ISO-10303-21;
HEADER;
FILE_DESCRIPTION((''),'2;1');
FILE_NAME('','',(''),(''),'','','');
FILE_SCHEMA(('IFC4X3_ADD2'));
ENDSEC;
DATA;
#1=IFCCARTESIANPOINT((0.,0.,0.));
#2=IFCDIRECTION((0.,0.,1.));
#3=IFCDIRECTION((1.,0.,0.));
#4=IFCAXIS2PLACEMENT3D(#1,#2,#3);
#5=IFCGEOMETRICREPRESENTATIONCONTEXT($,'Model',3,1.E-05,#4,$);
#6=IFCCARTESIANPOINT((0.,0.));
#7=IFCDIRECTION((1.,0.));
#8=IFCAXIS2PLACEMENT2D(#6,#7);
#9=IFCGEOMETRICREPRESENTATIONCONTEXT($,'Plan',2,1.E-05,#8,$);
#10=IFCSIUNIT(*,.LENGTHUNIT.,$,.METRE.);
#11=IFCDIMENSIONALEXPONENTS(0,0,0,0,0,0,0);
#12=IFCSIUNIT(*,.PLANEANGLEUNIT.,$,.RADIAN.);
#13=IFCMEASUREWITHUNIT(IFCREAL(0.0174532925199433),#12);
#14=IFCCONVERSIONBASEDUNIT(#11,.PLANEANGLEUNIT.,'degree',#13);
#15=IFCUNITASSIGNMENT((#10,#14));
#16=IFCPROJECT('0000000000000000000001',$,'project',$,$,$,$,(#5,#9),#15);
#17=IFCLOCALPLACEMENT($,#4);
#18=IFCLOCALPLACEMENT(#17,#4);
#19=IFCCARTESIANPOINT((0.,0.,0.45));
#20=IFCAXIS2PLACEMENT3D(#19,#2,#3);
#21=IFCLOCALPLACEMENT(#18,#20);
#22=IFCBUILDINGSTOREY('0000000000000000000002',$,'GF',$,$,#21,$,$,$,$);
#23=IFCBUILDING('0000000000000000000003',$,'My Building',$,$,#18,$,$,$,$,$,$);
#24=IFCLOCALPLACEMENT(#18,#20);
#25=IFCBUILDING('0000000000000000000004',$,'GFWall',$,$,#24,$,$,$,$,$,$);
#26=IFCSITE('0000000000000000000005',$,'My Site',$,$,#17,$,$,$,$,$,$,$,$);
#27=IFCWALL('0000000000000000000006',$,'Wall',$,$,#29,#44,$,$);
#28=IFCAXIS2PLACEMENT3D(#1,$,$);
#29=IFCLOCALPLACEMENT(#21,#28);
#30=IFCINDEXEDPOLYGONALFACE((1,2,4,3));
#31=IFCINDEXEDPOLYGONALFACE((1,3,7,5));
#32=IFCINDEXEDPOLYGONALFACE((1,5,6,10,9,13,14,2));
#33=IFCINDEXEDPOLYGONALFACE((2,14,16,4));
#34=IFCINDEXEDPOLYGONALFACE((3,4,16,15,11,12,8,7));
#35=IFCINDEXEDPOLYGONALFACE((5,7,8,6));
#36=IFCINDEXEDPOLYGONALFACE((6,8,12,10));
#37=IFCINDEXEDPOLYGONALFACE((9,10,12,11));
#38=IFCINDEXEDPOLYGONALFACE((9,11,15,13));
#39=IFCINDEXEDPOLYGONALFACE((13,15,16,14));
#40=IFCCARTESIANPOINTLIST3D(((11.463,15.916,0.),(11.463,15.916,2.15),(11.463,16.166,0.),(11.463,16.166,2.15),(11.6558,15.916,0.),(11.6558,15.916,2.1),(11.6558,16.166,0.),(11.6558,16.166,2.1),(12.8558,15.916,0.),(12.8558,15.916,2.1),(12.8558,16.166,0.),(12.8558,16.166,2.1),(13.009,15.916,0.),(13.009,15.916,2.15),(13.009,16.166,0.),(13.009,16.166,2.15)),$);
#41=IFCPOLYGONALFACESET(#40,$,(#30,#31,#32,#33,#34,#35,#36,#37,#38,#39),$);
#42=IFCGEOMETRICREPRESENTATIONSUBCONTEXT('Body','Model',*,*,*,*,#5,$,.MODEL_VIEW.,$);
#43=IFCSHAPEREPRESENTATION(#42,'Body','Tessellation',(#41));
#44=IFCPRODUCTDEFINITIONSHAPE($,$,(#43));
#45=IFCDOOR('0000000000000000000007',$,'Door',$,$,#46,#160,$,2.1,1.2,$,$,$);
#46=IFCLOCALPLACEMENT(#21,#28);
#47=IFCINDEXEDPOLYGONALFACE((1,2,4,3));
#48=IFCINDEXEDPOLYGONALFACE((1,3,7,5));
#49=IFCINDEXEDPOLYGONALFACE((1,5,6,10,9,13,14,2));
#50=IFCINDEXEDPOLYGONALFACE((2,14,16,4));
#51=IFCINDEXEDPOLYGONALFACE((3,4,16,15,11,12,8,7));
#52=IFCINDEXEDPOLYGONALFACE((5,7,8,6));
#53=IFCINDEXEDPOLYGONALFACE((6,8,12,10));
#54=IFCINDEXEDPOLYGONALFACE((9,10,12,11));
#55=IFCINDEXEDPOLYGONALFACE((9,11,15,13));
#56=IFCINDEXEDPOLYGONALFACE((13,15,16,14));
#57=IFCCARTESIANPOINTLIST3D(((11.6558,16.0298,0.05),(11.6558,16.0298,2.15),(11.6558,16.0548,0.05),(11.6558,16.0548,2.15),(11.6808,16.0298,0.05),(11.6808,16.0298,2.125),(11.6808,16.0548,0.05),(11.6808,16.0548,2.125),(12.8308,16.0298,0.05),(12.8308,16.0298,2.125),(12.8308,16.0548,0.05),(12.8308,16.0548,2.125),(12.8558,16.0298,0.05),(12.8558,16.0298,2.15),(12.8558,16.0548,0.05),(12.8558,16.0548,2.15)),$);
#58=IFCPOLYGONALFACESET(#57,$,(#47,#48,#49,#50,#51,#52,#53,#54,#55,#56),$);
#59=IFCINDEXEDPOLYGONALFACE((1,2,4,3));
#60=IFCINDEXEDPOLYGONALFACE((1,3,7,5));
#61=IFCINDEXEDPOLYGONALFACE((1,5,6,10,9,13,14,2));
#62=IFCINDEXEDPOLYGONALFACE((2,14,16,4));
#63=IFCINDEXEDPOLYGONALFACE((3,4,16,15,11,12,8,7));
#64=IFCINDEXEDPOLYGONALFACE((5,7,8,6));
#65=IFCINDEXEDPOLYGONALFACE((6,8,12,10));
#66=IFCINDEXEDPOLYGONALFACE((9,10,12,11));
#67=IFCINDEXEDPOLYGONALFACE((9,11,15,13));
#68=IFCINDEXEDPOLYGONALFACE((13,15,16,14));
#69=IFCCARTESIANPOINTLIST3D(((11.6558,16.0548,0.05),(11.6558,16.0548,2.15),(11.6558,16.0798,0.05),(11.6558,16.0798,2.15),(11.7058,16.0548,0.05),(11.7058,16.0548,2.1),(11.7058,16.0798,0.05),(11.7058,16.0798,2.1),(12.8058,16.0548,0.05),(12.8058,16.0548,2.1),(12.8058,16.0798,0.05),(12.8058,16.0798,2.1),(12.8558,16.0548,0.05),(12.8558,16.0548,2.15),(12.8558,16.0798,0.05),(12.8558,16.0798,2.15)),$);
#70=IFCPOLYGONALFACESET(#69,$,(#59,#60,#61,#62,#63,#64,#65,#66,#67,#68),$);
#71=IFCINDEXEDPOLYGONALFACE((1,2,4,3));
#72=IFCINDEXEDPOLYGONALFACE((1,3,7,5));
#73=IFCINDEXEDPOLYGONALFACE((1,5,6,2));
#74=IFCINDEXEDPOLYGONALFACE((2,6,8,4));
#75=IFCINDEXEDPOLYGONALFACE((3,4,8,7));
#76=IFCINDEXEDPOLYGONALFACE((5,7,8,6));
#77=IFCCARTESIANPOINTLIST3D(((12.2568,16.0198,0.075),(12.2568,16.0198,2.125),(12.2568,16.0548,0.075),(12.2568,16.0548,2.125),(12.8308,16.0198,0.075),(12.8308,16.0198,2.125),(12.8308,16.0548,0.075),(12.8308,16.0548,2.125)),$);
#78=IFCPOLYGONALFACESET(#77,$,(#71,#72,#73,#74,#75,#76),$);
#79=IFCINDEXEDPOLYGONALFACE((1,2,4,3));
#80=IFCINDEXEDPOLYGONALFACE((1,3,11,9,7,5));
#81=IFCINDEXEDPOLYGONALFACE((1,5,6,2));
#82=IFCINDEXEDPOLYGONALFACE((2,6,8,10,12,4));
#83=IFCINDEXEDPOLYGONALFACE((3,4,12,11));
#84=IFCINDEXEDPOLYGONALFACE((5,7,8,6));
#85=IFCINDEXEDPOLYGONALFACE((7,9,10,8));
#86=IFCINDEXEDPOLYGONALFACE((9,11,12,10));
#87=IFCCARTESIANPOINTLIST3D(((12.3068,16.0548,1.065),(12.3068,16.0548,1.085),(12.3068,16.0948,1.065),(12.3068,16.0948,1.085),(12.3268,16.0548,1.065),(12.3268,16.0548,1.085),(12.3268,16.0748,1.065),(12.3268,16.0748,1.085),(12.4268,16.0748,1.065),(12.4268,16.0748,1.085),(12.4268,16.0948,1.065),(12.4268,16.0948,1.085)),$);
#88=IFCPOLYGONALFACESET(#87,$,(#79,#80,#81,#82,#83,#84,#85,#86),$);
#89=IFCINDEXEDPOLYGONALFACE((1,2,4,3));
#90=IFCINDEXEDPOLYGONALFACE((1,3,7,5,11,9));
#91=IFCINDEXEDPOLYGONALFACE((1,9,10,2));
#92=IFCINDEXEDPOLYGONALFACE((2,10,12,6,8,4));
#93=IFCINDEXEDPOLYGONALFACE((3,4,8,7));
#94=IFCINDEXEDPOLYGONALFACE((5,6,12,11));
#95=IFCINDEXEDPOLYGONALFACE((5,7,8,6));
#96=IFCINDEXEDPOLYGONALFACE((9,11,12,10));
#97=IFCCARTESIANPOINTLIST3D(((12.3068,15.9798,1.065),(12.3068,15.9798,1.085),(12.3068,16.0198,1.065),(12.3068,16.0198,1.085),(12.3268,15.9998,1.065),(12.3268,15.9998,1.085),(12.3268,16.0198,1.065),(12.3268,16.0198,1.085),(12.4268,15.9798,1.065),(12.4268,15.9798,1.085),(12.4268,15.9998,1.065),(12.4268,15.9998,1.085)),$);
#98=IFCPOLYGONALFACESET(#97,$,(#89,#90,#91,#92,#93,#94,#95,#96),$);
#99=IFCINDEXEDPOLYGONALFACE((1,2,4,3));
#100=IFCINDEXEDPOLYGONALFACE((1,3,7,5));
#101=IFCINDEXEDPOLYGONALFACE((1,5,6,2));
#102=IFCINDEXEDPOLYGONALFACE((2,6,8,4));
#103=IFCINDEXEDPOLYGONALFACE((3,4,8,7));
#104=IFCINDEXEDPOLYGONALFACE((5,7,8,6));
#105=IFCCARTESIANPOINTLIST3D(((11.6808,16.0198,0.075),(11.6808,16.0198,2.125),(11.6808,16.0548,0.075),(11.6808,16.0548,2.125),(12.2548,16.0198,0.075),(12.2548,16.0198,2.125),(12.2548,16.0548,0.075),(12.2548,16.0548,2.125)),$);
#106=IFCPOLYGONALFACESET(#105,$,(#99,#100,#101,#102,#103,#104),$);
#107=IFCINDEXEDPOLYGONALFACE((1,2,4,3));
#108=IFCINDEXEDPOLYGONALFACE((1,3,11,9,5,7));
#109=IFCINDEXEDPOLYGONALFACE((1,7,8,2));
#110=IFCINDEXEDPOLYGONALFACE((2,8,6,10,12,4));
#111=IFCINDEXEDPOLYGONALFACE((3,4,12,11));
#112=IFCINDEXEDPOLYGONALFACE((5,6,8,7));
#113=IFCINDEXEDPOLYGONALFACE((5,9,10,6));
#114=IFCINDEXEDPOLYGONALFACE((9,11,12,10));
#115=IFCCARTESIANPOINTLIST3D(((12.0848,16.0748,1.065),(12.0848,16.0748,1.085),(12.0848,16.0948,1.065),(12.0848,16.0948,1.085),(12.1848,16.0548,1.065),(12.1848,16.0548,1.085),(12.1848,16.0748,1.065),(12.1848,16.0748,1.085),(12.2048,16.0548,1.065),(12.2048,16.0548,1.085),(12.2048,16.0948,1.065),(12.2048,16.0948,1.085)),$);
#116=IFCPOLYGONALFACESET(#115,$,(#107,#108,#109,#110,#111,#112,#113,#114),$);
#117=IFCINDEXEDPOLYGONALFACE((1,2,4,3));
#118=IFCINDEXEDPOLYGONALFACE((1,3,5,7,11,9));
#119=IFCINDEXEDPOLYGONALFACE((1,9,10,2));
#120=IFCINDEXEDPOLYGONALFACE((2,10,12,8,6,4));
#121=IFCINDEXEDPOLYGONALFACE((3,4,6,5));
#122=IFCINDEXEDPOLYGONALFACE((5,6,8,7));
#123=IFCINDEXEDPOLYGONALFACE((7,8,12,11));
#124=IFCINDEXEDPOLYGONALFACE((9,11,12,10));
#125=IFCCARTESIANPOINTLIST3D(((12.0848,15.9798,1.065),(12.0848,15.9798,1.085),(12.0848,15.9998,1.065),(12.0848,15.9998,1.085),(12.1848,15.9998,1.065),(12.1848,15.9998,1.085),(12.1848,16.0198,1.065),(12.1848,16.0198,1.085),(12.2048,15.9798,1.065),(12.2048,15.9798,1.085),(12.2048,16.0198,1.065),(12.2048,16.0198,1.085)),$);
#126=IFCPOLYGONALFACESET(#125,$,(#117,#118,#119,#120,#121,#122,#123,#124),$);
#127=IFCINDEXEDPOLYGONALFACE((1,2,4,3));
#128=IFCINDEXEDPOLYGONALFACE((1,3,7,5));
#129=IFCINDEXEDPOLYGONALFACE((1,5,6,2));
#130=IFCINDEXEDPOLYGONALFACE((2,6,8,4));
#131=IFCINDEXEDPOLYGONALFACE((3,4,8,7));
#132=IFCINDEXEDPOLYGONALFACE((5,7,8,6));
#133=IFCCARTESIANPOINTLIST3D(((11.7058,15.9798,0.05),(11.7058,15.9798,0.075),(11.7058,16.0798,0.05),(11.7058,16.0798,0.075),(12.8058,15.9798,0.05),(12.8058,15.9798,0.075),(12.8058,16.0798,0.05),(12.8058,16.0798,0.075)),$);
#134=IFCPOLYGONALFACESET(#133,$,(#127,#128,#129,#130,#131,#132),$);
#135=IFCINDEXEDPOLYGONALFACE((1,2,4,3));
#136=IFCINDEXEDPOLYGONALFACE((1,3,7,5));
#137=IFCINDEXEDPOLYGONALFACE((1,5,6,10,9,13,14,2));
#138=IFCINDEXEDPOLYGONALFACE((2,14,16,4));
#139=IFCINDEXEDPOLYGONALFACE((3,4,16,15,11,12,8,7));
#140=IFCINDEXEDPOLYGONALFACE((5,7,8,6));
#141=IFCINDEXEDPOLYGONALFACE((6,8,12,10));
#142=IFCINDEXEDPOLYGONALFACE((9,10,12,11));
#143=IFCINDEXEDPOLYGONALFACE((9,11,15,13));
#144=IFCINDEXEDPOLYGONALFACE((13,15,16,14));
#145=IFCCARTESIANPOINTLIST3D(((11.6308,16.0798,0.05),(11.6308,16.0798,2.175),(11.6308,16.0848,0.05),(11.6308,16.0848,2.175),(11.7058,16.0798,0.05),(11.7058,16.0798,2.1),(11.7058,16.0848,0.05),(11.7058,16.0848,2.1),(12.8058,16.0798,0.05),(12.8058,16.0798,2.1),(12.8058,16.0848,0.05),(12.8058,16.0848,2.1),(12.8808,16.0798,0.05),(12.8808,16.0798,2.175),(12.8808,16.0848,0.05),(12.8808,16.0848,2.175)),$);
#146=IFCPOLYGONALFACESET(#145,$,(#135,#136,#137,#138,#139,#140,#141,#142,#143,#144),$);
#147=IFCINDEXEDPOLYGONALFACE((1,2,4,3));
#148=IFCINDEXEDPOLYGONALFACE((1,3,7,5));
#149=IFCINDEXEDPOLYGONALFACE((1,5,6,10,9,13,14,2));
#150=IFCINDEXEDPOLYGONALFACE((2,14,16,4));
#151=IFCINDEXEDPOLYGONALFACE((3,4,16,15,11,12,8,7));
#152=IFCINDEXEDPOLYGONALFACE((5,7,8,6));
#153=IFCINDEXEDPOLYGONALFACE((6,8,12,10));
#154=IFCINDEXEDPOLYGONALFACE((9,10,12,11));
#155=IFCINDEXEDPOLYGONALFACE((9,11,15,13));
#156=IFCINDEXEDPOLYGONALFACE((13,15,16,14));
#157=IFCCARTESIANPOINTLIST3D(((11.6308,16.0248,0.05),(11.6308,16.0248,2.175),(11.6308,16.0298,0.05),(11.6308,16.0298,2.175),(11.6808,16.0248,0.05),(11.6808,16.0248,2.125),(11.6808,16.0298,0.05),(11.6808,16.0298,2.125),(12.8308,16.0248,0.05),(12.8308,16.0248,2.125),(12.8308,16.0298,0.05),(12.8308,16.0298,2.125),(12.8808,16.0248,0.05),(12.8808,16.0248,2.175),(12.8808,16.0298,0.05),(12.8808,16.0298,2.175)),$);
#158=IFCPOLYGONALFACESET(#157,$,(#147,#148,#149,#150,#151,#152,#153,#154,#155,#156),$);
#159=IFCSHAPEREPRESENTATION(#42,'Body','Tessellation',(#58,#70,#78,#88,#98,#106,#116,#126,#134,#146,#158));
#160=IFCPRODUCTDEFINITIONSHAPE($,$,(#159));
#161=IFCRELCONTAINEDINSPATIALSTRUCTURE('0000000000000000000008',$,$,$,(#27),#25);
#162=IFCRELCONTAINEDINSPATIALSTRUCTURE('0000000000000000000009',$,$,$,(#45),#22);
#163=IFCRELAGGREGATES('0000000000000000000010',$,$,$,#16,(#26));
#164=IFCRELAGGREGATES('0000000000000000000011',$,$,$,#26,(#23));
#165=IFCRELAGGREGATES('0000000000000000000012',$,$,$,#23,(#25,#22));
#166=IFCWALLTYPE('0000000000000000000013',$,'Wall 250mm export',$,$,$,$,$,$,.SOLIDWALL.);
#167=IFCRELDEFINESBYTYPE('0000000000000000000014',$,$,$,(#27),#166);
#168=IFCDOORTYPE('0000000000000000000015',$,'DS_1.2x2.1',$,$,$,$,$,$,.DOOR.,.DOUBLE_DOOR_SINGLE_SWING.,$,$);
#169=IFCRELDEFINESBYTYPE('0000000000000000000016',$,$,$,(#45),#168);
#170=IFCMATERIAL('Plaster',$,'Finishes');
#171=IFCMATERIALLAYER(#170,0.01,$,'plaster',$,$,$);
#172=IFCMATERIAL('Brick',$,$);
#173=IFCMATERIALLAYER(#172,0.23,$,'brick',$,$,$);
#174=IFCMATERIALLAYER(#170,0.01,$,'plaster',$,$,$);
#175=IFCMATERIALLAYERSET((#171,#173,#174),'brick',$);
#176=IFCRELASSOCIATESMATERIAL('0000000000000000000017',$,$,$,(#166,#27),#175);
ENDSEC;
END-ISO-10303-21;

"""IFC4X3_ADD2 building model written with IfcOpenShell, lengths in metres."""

from ifc_helpers import new_model, entity, si_unit, converted_unit, frame, origin_with_axes, origin_2d_with_axis, place, context, subcontext, project, spatial, line, indexed_curve, outline, extrude, shape, source, transform, mapped, material, layer, layer_set, layer_usage, type_object, type_shapes, element, fill, save


model = new_model("IFC4X3_ADD2")

# Units and contexts
model_context = context("Model", 3, precision=1e-05, world=origin_with_axes())
plan_context = context("Plan", 2, precision=1e-05, world=origin_2d_with_axis())
body_context_1 = subcontext(model_context, "Body", "Model", "MODEL_VIEW")
body_context_2 = subcontext(plan_context, "Body", "Plan", "PLAN_VIEW")
ifc_project = project(units=[si_unit("LENGTHUNIT", "METRE"), converted_unit("PLANEANGLEUNIT", "degree", entity("IfcReal", 0.0174532925199433), si_unit("PLANEANGLEUNIT", "RADIAN"), dimensions=[0, 0, 0, 0, 0, 0, 0])], contexts=[model_context, plan_context])

# Site, buildings
site_placement = place(None, origin_with_axes())
site = spatial("IfcSite", under=ifc_project, at=site_placement, Name="My Site")
building_1_placement = place(site_placement, origin_with_axes())
building_1 = spatial("IfcBuilding", under=site, at=building_1_placement, Name="My Building")
building_2_placement = place(building_1_placement, frame((0.0, 0.0, 0.45), z_axis=(0.0, 0.0, 1.0), x_axis=(1.0, 0.0, 0.0)))
building_2 = spatial("IfcBuilding", under=building_1, at=building_2_placement, Name="GFWall")

# Shared definitions
ifc_material_1 = material(Name="Plaster", Category="Finishes")

# Shared definitions
storey_placement = place(building_1_placement, frame((0.0, 0.0, 0.45), z_axis=(0.0, 0.0, 1.0), x_axis=(1.0, 0.0, 0.0)))
storey = spatial("IfcBuildingStorey", under=building_1, at=storey_placement, Name="GF")

# Shared definitions
ifc_layer_1 = layer(ifc_material_1, 0.01, Name="plaster")
ifc_material_2 = material(Name="Brick")
ifc_layer_2 = layer(ifc_material_2, 0.23, Name="brick")
ifc_layer_3 = layer(ifc_material_1, 0.01, Name="plaster")
ifc_layer_set_1 = layer_set([ifc_layer_1, ifc_layer_2, ifc_layer_3], Name="brick")
wall_type_1 = type_object("IfcWallType", Name="Wall 250mm export", PredefinedType="SOLIDWALL", material=ifc_layer_set_1)

# Wall, opening, door
shared_shape_1 = source(origin_with_axes(), body_context_1, "Body", "SweptSolid", [
    extrude(outline(indexed_curve([(0.0, 0.0), (1.2, 0.0), (1.2, 2.1), (0.0, 2.1)], segments=[line(1, 2, 3, 4, 1)])), frame((0.0, -0.6, 0.0), z_axis=(0.0, -1.0, 0.0), x_axis=(1.0, 0.0, 0.0)), (0.0, 0.0, -1.0), 1.2),
])
door_type_1 = type_object("IfcDoorType", Name="DS_1.2x2.1", OperationType="DOUBLE_DOOR_SINGLE_SWING", PredefinedType="DOOR")
shared_shape_2 = source(origin_with_axes(), body_context_1, "Body", "SweptSolid", [
    extrude(outline(indexed_curve([(0.0, 0.0), (0.0, 2.1), (1.2, 2.1), (1.2, 0.0), (1.175, 0.0), (1.175, 2.075), (0.025, 2.075), (0.025, 0.0)], segments=[line(1, 2, 3, 4, 5, 6, 7, 8, 1)])), frame((0.0, 0.025, 0.0), z_axis=(0.0, -1.0, 0.0), x_axis=(1.0, 0.0, 0.0)), (0.0, 0.0, -1.0), 0.025),
    extrude(outline(indexed_curve([(0.0, 0.0), (0.0, 2.1), (1.2, 2.1), (1.2, 0.0), (1.15, 0.0), (1.15, 2.05), (0.05, 2.05), (0.05, 0.0)], segments=[line(1, 2, 3, 4, 5, 6, 7, 8, 1)])), frame((0.0, 0.0, 0.0), z_axis=(0.0, -1.0, 0.0), x_axis=(1.0, 0.0, 0.0)), (0.0, 0.0, -1.0), 0.025),
    extrude(outline(indexed_curve([(0.0, 0.0), (0.574, 0.0), (0.574, 0.035), (0.0, 0.035)], segments=[line(1, 2, 3, 4, 1)])), frame((0.025, 0.025, 0.025), z_axis=(0.0, 0.0, 1.0), x_axis=(1.0, 0.0, 0.0)), (0.0, 0.0, 1.0), 2.05),
    extrude(outline(indexed_curve([(0.0, 0.0), (0.0, -0.04), (-0.12, -0.04), (-0.12, -0.02), (-0.02, -0.02), (-0.02, 0.0)], segments=[line(1, 2, 3, 4, 5, 6, 1)])), frame((0.549, 0.025, 1.015), z_axis=(0.0, 0.0, 1.0), x_axis=(1.0, 0.0, 0.0)), (0.0, 0.0, 1.0), 0.02),
    extrude(outline(indexed_curve([(0.0, 0.0), (0.0, 0.04), (-0.12, 0.04), (-0.12, 0.02), (-0.02, 0.02), (-0.02, 0.0)], segments=[line(1, 2, 3, 4, 5, 6, 1)])), frame((0.549, 0.06, 1.015), z_axis=(0.0, 0.0, 1.0), x_axis=(1.0, 0.0, 0.0)), (0.0, 0.0, 1.0), 0.02),
    extrude(outline(indexed_curve([(0.0, 0.0), (-0.574, 0.0), (-0.574, 0.035), (0.0, 0.035)], segments=[line(1, 2, 3, 4, 1)])), frame((1.175, 0.025, 0.025), z_axis=(0.0, 0.0, 1.0), x_axis=(1.0, 0.0, 0.0)), (0.0, 0.0, 1.0), 2.05),
    extrude(outline(indexed_curve([(0.0, 0.0), (0.0, -0.04), (0.12, -0.04), (0.12, -0.02), (0.02, -0.02), (0.02, 0.0)], segments=[line(1, 2, 3, 4, 5, 6, 1)])), frame((0.651, 0.025, 1.015), z_axis=(0.0, 0.0, 1.0), x_axis=(1.0, 0.0, 0.0)), (0.0, 0.0, 1.0), 0.02),
    extrude(outline(indexed_curve([(0.0, 0.0), (0.0, 0.04), (0.12, 0.04), (0.12, 0.02), (0.02, 0.02), (0.02, 0.0)], segments=[line(1, 2, 3, 4, 5, 6, 1)])), frame((0.651, 0.06, 1.015), z_axis=(0.0, 0.0, 1.0), x_axis=(1.0, 0.0, 0.0)), (0.0, 0.0, 1.0), 0.02),
    extrude(outline(indexed_curve([(0.0, 0.0), (1.1, 0.0), (1.1, 0.1), (0.0, 0.1)], segments=[line(1, 2, 3, 4, 1)])), frame((0.05, 0.0, 0.0), z_axis=(0.0, 0.0, 1.0), x_axis=(1.0, 0.0, 0.0)), (0.0, 0.0, 1.0), 0.025),
    extrude(outline(indexed_curve([(0.0, 0.0), (0.0, 2.125), (1.25, 2.125), (1.25, 0.0), (1.175, 0.0), (1.175, 2.05), (0.075, 2.05), (0.075, 0.0)], segments=[line(1, 2, 3, 4, 5, 6, 7, 8, 1)])), frame((-0.025, -0.005, 0.0), z_axis=(0.0, -1.0, 0.0), x_axis=(1.0, 0.0, 0.0)), (0.0, 0.0, -1.0), 0.005),
    extrude(outline(indexed_curve([(0.0, 0.0), (0.0, 2.125), (1.25, 2.125), (1.25, 0.0), (1.2, 0.0), (1.2, 2.075), (0.05, 2.075), (0.05, 0.0)], segments=[line(1, 2, 3, 4, 5, 6, 7, 8, 1)])), frame((-0.025, 0.05, 0.0), z_axis=(0.0, -1.0, 0.0), x_axis=(1.0, 0.0, 0.0)), (0.0, 0.0, -1.0), 0.005),
])
shared_shape_3 = source(origin_with_axes(), body_context_2, "Body", "Curve2D", [
    entity("IfcIndexedPolyCurve", entity("IfcCartesianPointList2D", [[0.0, 0.0], [0.0, 0.05], [0.025, 0.05], [0.025, 0.025], [0.05, 0.025], [0.05, 0.0]]), [entity("IfcLineIndex", [1, 2, 3, 4, 5, 6, 1])]),
    entity("IfcIndexedPolyCurve", entity("IfcCartesianPointList2D", [[1.2, 0.0], [1.2, 0.05], [1.175, 0.05], [1.175, 0.025], [1.15, 0.025], [1.15, 0.0]]), [entity("IfcLineIndex", [1, 2, 3, 4, 5, 6, 1])]),
    entity("IfcTrimmedCurve", entity("IfcEllipse", entity("IfcAxis2Placement2D", entity("IfcCartesianPoint", [0.06, 0.05]), entity("IfcDirection", [1.0, 0.0])), 0.54, 0.575), [entity("IfcCartesianPoint", [0.6, 0.05])], [entity("IfcCartesianPoint", [0.06, 0.625])], True, "CARTESIAN"),
    entity("IfcIndexedPolyCurve", entity("IfcCartesianPointList2D", [[0.025, 0.05], [0.06, 0.05], [0.06, 0.625], [0.025, 0.625]]), [entity("IfcLineIndex", [1, 2, 3, 4, 1])]),
    entity("IfcTrimmedCurve", entity("IfcEllipse", entity("IfcAxis2Placement2D", entity("IfcCartesianPoint", [1.14, 0.05]), entity("IfcDirection", [1.0, 0.0])), 0.54, 0.575), [entity("IfcCartesianPoint", [1.14, 0.625])], [entity("IfcCartesianPoint", [0.6, 0.05])], True, "CARTESIAN"),
    entity("IfcIndexedPolyCurve", entity("IfcCartesianPointList2D", [[1.175, 0.05], [1.14, 0.05], [1.14, 0.625], [1.175, 0.625]]), [entity("IfcLineIndex", [1, 2, 3, 4, 1])]),
])
type_shapes(door_type_1, [shared_shape_2, shared_shape_3])
ifc_layer_usage_1 = layer_usage(ifc_layer_set_1, "AXIS2", "POSITIVE", 0.0)
wall_1_placement = place(building_2_placement, frame((11.463, 15.916, 0.0), z_axis=(0.0, 0.0, 1.0), x_axis=(1.0, 0.0, 0.0)))
wall_1 = element("IfcWall", 1, at=wall_1_placement, inside=building_2, type_object=wall_type_1, material=ifc_layer_usage_1, Name="Wall", context=body_context_1, shape_type="SweptSolid", body=[
    extrude(outline(indexed_curve([(0.0, 0.0), (0.0, 0.25), (1.546, 0.25), (1.546, 0.0)], segments=[line(1, 2, 3, 4, 1)])), origin_with_axes(), (0.0, 0.0, 1.0), 2.15),
])
opening_1_placement = place(wall_1_placement, frame((1.3928, 0.1638, 0.0), z_axis=(0.0, 0.0, 1.0), x_axis=(-1.0, 0.0, 0.0)))
opening_1 = element("IfcOpeningElement", 2, at=opening_1_placement, cuts=wall_1, PredefinedType="OPENING", context=body_context_1, shape_type="MappedRepresentation", body=[
    mapped(shared_shape_1, transform((0.0, 0.0, 0.0), x_axis=(1.0, 0.0, 0.0), y_axis=(0.0, 1.0, 0.0), z_axis=(0.0, 0.0, 1.0), scale=1.0)),
])
door_1_placement = place(opening_1_placement, frame((0.0, 0.0, 0.05), z_axis=(0.0, 0.0, 1.0), x_axis=(1.0, 0.0, 0.0)))
door_1 = element("IfcDoor", 3, at=door_1_placement, inside=storey, type_object=door_type_1, Name="Door", OverallHeight=2.1, OverallWidth=1.2, shapes=[
    shape(body_context_1, "Body", "MappedRepresentation", [mapped(shared_shape_2, transform((0.0, 0.0, 0.0), x_axis=(1.0, 0.0, 0.0), y_axis=(0.0, 1.0, 0.0), z_axis=(0.0, 0.0, 1.0), scale=1.0))]),
    shape(body_context_2, "Body", "MappedRepresentation", [mapped(shared_shape_3, transform((0.0, 0.0, 0.0), x_axis=(1.0, 0.0, 0.0), y_axis=(0.0, 1.0, 0.0), z_axis=(0.0, 0.0, 1.0), scale=1.0))]),
])
fill(opening_1, door_1)

save(model, "model.ifc")
